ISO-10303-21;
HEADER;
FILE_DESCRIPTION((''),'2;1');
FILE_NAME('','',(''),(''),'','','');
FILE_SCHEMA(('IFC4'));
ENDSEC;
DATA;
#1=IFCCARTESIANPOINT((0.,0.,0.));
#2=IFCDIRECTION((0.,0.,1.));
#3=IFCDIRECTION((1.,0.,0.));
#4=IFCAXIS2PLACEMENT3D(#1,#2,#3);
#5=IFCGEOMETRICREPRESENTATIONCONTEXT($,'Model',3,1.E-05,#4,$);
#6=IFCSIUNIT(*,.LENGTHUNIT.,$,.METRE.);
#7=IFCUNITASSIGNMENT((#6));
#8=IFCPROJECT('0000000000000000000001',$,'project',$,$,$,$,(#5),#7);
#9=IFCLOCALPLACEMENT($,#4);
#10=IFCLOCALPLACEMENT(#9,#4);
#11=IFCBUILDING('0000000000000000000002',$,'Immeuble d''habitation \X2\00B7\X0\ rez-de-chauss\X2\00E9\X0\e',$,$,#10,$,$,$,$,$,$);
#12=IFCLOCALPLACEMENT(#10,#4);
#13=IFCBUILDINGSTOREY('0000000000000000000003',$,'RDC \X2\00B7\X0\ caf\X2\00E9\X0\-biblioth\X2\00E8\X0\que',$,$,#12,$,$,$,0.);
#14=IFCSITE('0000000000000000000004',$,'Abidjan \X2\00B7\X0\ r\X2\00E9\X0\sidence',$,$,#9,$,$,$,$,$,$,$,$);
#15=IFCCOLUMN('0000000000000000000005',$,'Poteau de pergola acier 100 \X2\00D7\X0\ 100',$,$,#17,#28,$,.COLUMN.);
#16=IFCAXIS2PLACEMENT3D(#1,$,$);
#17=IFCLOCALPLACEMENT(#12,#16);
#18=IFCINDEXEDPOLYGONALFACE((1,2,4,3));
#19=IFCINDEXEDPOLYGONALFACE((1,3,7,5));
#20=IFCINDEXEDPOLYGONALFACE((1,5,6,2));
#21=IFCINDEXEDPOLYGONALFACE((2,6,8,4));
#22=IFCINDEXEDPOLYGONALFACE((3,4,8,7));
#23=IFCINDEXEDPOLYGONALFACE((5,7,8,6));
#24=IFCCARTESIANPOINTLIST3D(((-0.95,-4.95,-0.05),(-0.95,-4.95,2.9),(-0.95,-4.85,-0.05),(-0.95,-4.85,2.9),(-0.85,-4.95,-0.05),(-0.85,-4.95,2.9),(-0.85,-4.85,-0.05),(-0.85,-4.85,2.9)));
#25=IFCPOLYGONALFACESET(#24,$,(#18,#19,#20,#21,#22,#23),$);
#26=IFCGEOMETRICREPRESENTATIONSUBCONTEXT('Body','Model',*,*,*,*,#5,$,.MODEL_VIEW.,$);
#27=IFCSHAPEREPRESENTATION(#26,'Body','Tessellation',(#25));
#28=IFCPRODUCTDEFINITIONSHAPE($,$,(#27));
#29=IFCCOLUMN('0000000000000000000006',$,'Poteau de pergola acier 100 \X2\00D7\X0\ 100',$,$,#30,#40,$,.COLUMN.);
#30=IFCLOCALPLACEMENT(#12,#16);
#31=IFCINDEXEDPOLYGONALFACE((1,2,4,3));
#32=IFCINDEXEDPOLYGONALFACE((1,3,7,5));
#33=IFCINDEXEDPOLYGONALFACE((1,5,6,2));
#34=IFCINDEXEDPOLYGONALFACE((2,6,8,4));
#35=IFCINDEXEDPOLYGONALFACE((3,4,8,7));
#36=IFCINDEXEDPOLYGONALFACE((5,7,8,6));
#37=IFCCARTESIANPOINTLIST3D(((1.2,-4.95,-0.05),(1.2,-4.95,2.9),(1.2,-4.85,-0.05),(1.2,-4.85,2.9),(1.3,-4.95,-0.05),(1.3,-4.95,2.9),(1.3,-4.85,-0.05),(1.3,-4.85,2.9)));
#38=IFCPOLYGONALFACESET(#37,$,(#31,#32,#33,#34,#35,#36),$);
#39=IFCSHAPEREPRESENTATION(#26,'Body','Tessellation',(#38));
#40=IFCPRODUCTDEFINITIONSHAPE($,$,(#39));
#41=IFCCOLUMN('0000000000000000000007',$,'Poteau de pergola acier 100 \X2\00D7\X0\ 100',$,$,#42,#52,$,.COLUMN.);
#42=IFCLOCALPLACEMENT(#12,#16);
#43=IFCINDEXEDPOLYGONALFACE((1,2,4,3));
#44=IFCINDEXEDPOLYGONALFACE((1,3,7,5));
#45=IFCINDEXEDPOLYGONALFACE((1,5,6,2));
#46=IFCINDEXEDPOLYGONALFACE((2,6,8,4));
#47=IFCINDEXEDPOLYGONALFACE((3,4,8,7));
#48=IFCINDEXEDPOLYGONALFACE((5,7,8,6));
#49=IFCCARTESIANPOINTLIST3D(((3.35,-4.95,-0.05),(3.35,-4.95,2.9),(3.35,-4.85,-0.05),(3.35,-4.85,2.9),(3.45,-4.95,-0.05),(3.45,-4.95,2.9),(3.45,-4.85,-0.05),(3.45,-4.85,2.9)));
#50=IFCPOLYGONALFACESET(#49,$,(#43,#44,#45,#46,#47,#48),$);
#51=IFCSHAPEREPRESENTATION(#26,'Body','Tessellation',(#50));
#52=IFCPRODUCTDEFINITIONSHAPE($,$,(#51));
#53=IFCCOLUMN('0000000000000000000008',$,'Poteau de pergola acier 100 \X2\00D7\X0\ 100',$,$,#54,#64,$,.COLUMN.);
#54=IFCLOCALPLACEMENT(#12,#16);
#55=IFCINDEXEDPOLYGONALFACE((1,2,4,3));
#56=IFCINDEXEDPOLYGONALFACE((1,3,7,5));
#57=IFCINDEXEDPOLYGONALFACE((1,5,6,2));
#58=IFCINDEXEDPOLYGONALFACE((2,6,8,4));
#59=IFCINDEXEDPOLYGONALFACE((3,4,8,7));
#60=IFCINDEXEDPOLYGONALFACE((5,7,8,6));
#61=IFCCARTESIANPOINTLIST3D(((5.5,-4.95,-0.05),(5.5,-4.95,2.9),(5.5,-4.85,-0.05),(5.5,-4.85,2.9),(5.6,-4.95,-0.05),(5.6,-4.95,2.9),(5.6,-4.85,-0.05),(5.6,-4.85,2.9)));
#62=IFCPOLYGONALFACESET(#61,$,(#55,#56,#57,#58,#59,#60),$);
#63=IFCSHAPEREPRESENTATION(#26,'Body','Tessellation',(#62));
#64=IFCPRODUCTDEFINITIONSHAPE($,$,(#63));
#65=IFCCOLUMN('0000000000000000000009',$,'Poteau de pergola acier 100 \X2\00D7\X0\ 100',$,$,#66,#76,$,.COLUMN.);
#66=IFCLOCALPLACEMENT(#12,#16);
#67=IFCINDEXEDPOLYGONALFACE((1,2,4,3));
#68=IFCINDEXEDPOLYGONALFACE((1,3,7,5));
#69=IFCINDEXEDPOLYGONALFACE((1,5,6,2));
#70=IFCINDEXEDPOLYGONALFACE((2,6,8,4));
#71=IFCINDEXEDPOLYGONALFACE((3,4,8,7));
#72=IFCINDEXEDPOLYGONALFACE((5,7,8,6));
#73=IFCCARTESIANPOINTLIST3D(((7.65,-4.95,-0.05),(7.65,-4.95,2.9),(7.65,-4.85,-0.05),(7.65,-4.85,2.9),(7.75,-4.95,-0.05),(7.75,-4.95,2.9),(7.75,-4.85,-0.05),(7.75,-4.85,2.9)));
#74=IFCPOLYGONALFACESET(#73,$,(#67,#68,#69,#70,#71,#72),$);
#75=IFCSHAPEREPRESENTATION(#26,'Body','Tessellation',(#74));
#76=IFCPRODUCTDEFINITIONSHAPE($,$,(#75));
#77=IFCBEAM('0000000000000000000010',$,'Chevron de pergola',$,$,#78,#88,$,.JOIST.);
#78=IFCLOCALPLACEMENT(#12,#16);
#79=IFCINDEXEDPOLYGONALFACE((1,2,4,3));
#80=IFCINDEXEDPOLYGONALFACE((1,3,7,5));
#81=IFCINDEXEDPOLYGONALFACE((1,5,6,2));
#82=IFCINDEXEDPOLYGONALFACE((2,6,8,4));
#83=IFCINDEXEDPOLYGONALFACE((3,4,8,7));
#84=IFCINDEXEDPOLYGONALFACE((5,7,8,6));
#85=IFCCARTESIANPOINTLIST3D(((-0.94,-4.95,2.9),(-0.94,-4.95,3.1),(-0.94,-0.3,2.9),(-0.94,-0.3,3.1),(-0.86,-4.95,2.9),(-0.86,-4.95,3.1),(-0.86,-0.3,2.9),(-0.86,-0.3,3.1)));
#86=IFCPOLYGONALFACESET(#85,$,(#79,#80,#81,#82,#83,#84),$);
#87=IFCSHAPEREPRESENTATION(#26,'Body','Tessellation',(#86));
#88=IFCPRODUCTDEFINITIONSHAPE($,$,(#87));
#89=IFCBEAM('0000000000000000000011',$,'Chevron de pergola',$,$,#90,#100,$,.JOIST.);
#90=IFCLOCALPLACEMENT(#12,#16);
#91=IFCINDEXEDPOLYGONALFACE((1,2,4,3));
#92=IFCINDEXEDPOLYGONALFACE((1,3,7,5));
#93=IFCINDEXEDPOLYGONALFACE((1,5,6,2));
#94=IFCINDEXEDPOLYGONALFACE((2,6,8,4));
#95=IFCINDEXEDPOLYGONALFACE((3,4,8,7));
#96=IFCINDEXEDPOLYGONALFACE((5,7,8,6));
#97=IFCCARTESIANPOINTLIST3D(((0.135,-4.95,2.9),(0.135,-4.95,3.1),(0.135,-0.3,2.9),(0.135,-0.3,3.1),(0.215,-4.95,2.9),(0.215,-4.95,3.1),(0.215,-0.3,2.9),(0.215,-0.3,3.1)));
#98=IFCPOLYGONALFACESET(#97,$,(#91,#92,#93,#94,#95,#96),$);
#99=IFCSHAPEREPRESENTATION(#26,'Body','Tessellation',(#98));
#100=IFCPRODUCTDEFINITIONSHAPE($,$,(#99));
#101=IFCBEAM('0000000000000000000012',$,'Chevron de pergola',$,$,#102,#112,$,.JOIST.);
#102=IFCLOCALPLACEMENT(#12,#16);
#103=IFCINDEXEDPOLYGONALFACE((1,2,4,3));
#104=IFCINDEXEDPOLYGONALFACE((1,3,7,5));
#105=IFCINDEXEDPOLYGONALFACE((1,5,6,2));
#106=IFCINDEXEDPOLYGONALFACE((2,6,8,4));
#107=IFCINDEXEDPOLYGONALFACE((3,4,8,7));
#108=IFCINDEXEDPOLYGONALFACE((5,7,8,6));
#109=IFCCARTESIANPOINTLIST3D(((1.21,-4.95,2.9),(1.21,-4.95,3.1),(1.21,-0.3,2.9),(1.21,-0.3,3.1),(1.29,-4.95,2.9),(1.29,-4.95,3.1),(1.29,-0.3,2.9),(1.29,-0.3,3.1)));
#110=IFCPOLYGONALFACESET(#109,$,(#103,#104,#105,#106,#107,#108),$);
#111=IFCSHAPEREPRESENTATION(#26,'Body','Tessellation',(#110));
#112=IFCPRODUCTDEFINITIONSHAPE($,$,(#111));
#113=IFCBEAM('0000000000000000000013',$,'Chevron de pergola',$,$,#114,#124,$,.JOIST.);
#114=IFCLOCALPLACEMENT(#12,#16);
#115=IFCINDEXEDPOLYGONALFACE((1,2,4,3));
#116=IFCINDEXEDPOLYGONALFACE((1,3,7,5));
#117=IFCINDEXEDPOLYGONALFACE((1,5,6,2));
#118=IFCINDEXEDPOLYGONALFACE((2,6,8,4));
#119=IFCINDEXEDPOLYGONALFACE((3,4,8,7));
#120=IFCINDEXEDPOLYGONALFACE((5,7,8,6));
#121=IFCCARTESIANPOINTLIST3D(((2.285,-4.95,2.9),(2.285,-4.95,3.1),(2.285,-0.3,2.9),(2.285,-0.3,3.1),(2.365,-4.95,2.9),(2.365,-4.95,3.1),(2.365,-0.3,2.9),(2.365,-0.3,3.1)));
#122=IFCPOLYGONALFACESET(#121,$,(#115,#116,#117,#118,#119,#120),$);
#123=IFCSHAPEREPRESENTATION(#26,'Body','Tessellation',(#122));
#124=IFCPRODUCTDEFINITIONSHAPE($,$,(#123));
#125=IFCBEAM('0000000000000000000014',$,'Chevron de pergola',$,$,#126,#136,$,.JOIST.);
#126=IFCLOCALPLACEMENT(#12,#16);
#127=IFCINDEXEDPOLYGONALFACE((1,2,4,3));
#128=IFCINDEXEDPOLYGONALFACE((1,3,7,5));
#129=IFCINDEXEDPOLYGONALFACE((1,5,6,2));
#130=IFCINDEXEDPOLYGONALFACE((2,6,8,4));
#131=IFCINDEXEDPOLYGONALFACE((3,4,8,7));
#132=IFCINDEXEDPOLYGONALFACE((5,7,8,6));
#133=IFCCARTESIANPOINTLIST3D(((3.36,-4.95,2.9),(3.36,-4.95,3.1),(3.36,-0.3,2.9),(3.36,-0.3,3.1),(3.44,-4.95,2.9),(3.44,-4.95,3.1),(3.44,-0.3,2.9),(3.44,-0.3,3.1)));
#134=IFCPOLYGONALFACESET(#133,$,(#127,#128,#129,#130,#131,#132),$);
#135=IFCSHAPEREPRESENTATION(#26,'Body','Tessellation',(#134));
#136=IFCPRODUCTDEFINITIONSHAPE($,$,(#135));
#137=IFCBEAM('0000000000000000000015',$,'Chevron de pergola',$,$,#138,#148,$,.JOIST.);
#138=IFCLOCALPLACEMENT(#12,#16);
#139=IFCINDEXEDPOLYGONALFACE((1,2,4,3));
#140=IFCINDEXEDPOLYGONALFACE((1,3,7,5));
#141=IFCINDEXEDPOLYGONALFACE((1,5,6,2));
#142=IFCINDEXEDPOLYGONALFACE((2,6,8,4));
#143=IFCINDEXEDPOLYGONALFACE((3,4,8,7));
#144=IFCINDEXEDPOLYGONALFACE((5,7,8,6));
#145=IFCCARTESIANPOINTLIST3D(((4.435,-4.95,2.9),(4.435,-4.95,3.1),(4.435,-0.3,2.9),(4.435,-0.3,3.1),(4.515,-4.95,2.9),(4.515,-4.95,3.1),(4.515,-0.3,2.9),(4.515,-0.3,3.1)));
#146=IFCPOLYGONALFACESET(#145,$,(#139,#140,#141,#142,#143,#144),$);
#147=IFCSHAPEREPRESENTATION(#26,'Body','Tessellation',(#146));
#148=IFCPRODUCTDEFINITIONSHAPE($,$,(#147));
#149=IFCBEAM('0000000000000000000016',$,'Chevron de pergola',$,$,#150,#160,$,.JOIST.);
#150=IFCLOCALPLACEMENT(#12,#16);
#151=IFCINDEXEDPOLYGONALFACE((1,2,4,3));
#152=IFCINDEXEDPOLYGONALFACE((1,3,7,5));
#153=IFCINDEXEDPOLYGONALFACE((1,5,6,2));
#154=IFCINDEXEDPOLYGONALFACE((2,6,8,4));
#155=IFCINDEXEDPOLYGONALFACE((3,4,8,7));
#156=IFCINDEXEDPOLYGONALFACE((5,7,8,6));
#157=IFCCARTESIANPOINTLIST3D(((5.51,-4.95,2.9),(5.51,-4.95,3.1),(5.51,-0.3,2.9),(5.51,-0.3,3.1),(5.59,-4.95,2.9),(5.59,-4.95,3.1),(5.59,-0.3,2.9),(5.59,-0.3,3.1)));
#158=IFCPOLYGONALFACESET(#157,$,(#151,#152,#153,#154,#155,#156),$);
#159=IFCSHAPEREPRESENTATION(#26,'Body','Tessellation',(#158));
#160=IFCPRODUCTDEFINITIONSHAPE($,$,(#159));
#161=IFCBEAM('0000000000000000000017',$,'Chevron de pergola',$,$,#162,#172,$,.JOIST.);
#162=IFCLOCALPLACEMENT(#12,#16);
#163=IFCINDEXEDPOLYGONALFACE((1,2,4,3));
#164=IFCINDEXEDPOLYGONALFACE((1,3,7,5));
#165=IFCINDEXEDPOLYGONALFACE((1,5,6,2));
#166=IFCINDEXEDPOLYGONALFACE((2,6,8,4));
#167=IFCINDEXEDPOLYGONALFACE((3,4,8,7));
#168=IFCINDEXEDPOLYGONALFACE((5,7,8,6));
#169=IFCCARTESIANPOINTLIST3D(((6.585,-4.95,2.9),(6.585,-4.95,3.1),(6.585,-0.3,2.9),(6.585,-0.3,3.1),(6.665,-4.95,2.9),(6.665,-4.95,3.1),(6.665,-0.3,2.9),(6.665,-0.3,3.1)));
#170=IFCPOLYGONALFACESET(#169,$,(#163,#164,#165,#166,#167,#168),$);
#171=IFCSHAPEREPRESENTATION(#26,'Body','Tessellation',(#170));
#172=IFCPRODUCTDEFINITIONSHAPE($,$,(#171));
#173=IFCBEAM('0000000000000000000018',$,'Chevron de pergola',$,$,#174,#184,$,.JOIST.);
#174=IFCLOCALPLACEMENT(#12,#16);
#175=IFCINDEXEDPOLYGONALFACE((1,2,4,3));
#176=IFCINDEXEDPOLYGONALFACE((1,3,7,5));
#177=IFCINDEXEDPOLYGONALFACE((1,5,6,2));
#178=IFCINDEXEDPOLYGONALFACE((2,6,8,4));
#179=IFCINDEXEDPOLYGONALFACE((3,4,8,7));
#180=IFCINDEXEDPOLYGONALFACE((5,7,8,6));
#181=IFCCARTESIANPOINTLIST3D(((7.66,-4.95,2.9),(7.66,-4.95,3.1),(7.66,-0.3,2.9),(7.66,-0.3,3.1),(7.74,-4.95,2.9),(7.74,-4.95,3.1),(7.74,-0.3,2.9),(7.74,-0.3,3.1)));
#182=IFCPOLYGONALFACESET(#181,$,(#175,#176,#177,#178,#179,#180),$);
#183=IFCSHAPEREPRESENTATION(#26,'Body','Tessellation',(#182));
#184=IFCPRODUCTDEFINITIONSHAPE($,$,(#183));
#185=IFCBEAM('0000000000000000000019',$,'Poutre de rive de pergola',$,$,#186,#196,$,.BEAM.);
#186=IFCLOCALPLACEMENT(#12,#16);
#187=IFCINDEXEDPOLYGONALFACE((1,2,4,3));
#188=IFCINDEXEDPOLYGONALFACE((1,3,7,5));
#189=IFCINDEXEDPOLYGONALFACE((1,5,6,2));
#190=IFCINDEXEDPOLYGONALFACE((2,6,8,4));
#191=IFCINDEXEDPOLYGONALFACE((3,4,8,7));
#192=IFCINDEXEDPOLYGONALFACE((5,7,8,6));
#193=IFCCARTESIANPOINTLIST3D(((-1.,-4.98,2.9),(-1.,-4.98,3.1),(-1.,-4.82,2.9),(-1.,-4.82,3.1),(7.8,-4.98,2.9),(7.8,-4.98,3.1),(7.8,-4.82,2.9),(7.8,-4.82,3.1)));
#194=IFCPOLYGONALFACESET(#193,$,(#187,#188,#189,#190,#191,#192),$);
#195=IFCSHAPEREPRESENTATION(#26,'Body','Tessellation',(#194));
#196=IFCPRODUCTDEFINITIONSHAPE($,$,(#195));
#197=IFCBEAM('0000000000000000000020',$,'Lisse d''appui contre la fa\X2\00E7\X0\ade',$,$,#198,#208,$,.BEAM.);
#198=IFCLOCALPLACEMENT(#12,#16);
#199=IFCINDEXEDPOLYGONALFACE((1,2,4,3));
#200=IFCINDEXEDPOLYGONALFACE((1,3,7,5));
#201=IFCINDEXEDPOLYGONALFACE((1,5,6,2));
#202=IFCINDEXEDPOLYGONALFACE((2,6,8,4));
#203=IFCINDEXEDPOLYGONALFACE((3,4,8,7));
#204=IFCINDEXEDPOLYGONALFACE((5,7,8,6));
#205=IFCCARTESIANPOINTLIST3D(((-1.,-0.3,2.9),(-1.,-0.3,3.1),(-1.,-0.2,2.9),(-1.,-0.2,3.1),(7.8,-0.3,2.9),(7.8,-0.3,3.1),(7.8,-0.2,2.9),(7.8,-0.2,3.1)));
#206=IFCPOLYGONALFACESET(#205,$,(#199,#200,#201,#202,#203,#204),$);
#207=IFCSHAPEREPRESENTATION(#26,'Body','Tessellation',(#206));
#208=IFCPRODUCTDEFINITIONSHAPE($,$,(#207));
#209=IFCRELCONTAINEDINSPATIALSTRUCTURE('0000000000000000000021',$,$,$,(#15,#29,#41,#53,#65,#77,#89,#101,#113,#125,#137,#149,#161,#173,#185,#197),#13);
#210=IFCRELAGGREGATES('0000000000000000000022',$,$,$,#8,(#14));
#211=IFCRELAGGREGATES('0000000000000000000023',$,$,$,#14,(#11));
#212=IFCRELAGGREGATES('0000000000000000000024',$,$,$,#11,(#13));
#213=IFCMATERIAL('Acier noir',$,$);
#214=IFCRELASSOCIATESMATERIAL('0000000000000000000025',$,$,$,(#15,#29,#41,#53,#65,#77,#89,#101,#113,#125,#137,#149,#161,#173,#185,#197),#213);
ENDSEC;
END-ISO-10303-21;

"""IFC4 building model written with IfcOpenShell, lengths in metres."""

from ifc_helpers import new_model, si_unit, frame, frame_2d, origin_with_axes, place, context, subcontext, project, spatial, rectangle, extrude, material, element, save


model = new_model("IFC4")

# Units and contexts
model_context = context("Model", 3, precision=1e-05, world=origin_with_axes())
body_context = subcontext(model_context, "Body", "Model", "MODEL_VIEW")
ifc_project = project(units=[si_unit("LENGTHUNIT", "METRE")], contexts=[model_context])

# Site, building, storey
site_placement = place(None, origin_with_axes())
site = spatial("IfcSite", under=ifc_project, at=site_placement, Name="Abidjan · résidence")
building_placement = place(site_placement, origin_with_axes())
building = spatial("IfcBuilding", under=site, at=building_placement, Name="Immeuble d'habitation · rez-de-chaussée")
storey_placement = place(building_placement, origin_with_axes())
storey = spatial("IfcBuildingStorey", under=building, at=storey_placement, Name="RDC · café-bibliothèque", Elevation=0.0)

# Columns
ifc_material_1 = material(Name="Acier noir")
column_1_placement = place(storey_placement, origin_with_axes())
element("IfcColumn", 1, at=column_1_placement, inside=storey, material=ifc_material_1, Name="Poteau de pergola acier 100 × 100", PredefinedType="COLUMN", context=body_context, shape_type="SweptSolid", body=[
    extrude(rectangle(XDim=0.1, YDim=0.1, at=frame_2d((-0.9, -4.9))), frame((0.0, 0.0, -0.05)), (0.0, 0.0, 1.0), 2.95),
])
column_2_placement = place(storey_placement, origin_with_axes())
element("IfcColumn", 2, at=column_2_placement, inside=storey, material=ifc_material_1, Name="Poteau de pergola acier 100 × 100", PredefinedType="COLUMN", context=body_context, shape_type="SweptSolid", body=[
    extrude(rectangle(XDim=0.1, YDim=0.1, at=frame_2d((1.25, -4.9))), frame((0.0, 0.0, -0.05)), (0.0, 0.0, 1.0), 2.95),
])
column_3_placement = place(storey_placement, origin_with_axes())
element("IfcColumn", 3, at=column_3_placement, inside=storey, material=ifc_material_1, Name="Poteau de pergola acier 100 × 100", PredefinedType="COLUMN", context=body_context, shape_type="SweptSolid", body=[
    extrude(rectangle(XDim=0.1, YDim=0.1, at=frame_2d((3.4, -4.9))), frame((0.0, 0.0, -0.05)), (0.0, 0.0, 1.0), 2.95),
])
column_4_placement = place(storey_placement, origin_with_axes())
element("IfcColumn", 4, at=column_4_placement, inside=storey, material=ifc_material_1, Name="Poteau de pergola acier 100 × 100", PredefinedType="COLUMN", context=body_context, shape_type="SweptSolid", body=[
    extrude(rectangle(XDim=0.1, YDim=0.1, at=frame_2d((5.55, -4.9))), frame((0.0, 0.0, -0.05)), (0.0, 0.0, 1.0), 2.95),
])
column_5_placement = place(storey_placement, origin_with_axes())
element("IfcColumn", 5, at=column_5_placement, inside=storey, material=ifc_material_1, Name="Poteau de pergola acier 100 × 100", PredefinedType="COLUMN", context=body_context, shape_type="SweptSolid", body=[
    extrude(rectangle(XDim=0.1, YDim=0.1, at=frame_2d((7.7, -4.9))), frame((0.0, 0.0, -0.05)), (0.0, 0.0, 1.0), 2.95),
])

# Beams
beam_1_placement = place(storey_placement, origin_with_axes())
element("IfcBeam", 6, at=beam_1_placement, inside=storey, material=ifc_material_1, Name="Chevron de pergola", PredefinedType="JOIST", context=body_context, shape_type="SweptSolid", body=[
    extrude(rectangle(XDim=0.08, YDim=4.65, at=frame_2d((-0.9, -2.625))), frame((0.0, 0.0, 2.9)), (0.0, 0.0, 1.0), 0.2),
])
beam_2_placement = place(storey_placement, origin_with_axes())
element("IfcBeam", 7, at=beam_2_placement, inside=storey, material=ifc_material_1, Name="Chevron de pergola", PredefinedType="JOIST", context=body_context, shape_type="SweptSolid", body=[
    extrude(rectangle(XDim=0.08, YDim=4.65, at=frame_2d((0.175, -2.625))), frame((0.0, 0.0, 2.9)), (0.0, 0.0, 1.0), 0.2),
])
beam_3_placement = place(storey_placement, origin_with_axes())
element("IfcBeam", 8, at=beam_3_placement, inside=storey, material=ifc_material_1, Name="Chevron de pergola", PredefinedType="JOIST", context=body_context, shape_type="SweptSolid", body=[
    extrude(rectangle(XDim=0.08, YDim=4.65, at=frame_2d((1.25, -2.625))), frame((0.0, 0.0, 2.9)), (0.0, 0.0, 1.0), 0.2),
])
beam_4_placement = place(storey_placement, origin_with_axes())
element("IfcBeam", 9, at=beam_4_placement, inside=storey, material=ifc_material_1, Name="Chevron de pergola", PredefinedType="JOIST", context=body_context, shape_type="SweptSolid", body=[
    extrude(rectangle(XDim=0.08, YDim=4.65, at=frame_2d((2.325, -2.625))), frame((0.0, 0.0, 2.9)), (0.0, 0.0, 1.0), 0.2),
])
beam_5_placement = place(storey_placement, origin_with_axes())
element("IfcBeam", 10, at=beam_5_placement, inside=storey, material=ifc_material_1, Name="Chevron de pergola", PredefinedType="JOIST", context=body_context, shape_type="SweptSolid", body=[
    extrude(rectangle(XDim=0.08, YDim=4.65, at=frame_2d((3.4, -2.625))), frame((0.0, 0.0, 2.9)), (0.0, 0.0, 1.0), 0.2),
])
beam_6_placement = place(storey_placement, origin_with_axes())
element("IfcBeam", 11, at=beam_6_placement, inside=storey, material=ifc_material_1, Name="Chevron de pergola", PredefinedType="JOIST", context=body_context, shape_type="SweptSolid", body=[
    extrude(rectangle(XDim=0.08, YDim=4.65, at=frame_2d((4.475, -2.625))), frame((0.0, 0.0, 2.9)), (0.0, 0.0, 1.0), 0.2),
])
beam_7_placement = place(storey_placement, origin_with_axes())
element("IfcBeam", 12, at=beam_7_placement, inside=storey, material=ifc_material_1, Name="Chevron de pergola", PredefinedType="JOIST", context=body_context, shape_type="SweptSolid", body=[
    extrude(rectangle(XDim=0.08, YDim=4.65, at=frame_2d((5.55, -2.625))), frame((0.0, 0.0, 2.9)), (0.0, 0.0, 1.0), 0.2),
])
beam_8_placement = place(storey_placement, origin_with_axes())
element("IfcBeam", 13, at=beam_8_placement, inside=storey, material=ifc_material_1, Name="Chevron de pergola", PredefinedType="JOIST", context=body_context, shape_type="SweptSolid", body=[
    extrude(rectangle(XDim=0.08, YDim=4.65, at=frame_2d((6.625, -2.625))), frame((0.0, 0.0, 2.9)), (0.0, 0.0, 1.0), 0.2),
])
beam_9_placement = place(storey_placement, origin_with_axes())
element("IfcBeam", 14, at=beam_9_placement, inside=storey, material=ifc_material_1, Name="Chevron de pergola", PredefinedType="JOIST", context=body_context, shape_type="SweptSolid", body=[
    extrude(rectangle(XDim=0.08, YDim=4.65, at=frame_2d((7.7, -2.625))), frame((0.0, 0.0, 2.9)), (0.0, 0.0, 1.0), 0.2),
])
beam_10_placement = place(storey_placement, origin_with_axes())
element("IfcBeam", 15, at=beam_10_placement, inside=storey, material=ifc_material_1, Name="Poutre de rive de pergola", PredefinedType="BEAM", context=body_context, shape_type="SweptSolid", body=[
    extrude(rectangle(XDim=8.8, YDim=0.16, at=frame_2d((3.4, -4.9))), frame((0.0, 0.0, 2.9)), (0.0, 0.0, 1.0), 0.2),
])
beam_11_placement = place(storey_placement, origin_with_axes())
element("IfcBeam", 16, at=beam_11_placement, inside=storey, material=ifc_material_1, Name="Lisse d'appui contre la façade", PredefinedType="BEAM", context=body_context, shape_type="SweptSolid", body=[
    extrude(rectangle(XDim=8.8, YDim=0.1, at=frame_2d((3.4, -0.25))), frame((0.0, 0.0, 2.9)), (0.0, 0.0, 1.0), 0.2),
])

save(model, "model.ifc")
